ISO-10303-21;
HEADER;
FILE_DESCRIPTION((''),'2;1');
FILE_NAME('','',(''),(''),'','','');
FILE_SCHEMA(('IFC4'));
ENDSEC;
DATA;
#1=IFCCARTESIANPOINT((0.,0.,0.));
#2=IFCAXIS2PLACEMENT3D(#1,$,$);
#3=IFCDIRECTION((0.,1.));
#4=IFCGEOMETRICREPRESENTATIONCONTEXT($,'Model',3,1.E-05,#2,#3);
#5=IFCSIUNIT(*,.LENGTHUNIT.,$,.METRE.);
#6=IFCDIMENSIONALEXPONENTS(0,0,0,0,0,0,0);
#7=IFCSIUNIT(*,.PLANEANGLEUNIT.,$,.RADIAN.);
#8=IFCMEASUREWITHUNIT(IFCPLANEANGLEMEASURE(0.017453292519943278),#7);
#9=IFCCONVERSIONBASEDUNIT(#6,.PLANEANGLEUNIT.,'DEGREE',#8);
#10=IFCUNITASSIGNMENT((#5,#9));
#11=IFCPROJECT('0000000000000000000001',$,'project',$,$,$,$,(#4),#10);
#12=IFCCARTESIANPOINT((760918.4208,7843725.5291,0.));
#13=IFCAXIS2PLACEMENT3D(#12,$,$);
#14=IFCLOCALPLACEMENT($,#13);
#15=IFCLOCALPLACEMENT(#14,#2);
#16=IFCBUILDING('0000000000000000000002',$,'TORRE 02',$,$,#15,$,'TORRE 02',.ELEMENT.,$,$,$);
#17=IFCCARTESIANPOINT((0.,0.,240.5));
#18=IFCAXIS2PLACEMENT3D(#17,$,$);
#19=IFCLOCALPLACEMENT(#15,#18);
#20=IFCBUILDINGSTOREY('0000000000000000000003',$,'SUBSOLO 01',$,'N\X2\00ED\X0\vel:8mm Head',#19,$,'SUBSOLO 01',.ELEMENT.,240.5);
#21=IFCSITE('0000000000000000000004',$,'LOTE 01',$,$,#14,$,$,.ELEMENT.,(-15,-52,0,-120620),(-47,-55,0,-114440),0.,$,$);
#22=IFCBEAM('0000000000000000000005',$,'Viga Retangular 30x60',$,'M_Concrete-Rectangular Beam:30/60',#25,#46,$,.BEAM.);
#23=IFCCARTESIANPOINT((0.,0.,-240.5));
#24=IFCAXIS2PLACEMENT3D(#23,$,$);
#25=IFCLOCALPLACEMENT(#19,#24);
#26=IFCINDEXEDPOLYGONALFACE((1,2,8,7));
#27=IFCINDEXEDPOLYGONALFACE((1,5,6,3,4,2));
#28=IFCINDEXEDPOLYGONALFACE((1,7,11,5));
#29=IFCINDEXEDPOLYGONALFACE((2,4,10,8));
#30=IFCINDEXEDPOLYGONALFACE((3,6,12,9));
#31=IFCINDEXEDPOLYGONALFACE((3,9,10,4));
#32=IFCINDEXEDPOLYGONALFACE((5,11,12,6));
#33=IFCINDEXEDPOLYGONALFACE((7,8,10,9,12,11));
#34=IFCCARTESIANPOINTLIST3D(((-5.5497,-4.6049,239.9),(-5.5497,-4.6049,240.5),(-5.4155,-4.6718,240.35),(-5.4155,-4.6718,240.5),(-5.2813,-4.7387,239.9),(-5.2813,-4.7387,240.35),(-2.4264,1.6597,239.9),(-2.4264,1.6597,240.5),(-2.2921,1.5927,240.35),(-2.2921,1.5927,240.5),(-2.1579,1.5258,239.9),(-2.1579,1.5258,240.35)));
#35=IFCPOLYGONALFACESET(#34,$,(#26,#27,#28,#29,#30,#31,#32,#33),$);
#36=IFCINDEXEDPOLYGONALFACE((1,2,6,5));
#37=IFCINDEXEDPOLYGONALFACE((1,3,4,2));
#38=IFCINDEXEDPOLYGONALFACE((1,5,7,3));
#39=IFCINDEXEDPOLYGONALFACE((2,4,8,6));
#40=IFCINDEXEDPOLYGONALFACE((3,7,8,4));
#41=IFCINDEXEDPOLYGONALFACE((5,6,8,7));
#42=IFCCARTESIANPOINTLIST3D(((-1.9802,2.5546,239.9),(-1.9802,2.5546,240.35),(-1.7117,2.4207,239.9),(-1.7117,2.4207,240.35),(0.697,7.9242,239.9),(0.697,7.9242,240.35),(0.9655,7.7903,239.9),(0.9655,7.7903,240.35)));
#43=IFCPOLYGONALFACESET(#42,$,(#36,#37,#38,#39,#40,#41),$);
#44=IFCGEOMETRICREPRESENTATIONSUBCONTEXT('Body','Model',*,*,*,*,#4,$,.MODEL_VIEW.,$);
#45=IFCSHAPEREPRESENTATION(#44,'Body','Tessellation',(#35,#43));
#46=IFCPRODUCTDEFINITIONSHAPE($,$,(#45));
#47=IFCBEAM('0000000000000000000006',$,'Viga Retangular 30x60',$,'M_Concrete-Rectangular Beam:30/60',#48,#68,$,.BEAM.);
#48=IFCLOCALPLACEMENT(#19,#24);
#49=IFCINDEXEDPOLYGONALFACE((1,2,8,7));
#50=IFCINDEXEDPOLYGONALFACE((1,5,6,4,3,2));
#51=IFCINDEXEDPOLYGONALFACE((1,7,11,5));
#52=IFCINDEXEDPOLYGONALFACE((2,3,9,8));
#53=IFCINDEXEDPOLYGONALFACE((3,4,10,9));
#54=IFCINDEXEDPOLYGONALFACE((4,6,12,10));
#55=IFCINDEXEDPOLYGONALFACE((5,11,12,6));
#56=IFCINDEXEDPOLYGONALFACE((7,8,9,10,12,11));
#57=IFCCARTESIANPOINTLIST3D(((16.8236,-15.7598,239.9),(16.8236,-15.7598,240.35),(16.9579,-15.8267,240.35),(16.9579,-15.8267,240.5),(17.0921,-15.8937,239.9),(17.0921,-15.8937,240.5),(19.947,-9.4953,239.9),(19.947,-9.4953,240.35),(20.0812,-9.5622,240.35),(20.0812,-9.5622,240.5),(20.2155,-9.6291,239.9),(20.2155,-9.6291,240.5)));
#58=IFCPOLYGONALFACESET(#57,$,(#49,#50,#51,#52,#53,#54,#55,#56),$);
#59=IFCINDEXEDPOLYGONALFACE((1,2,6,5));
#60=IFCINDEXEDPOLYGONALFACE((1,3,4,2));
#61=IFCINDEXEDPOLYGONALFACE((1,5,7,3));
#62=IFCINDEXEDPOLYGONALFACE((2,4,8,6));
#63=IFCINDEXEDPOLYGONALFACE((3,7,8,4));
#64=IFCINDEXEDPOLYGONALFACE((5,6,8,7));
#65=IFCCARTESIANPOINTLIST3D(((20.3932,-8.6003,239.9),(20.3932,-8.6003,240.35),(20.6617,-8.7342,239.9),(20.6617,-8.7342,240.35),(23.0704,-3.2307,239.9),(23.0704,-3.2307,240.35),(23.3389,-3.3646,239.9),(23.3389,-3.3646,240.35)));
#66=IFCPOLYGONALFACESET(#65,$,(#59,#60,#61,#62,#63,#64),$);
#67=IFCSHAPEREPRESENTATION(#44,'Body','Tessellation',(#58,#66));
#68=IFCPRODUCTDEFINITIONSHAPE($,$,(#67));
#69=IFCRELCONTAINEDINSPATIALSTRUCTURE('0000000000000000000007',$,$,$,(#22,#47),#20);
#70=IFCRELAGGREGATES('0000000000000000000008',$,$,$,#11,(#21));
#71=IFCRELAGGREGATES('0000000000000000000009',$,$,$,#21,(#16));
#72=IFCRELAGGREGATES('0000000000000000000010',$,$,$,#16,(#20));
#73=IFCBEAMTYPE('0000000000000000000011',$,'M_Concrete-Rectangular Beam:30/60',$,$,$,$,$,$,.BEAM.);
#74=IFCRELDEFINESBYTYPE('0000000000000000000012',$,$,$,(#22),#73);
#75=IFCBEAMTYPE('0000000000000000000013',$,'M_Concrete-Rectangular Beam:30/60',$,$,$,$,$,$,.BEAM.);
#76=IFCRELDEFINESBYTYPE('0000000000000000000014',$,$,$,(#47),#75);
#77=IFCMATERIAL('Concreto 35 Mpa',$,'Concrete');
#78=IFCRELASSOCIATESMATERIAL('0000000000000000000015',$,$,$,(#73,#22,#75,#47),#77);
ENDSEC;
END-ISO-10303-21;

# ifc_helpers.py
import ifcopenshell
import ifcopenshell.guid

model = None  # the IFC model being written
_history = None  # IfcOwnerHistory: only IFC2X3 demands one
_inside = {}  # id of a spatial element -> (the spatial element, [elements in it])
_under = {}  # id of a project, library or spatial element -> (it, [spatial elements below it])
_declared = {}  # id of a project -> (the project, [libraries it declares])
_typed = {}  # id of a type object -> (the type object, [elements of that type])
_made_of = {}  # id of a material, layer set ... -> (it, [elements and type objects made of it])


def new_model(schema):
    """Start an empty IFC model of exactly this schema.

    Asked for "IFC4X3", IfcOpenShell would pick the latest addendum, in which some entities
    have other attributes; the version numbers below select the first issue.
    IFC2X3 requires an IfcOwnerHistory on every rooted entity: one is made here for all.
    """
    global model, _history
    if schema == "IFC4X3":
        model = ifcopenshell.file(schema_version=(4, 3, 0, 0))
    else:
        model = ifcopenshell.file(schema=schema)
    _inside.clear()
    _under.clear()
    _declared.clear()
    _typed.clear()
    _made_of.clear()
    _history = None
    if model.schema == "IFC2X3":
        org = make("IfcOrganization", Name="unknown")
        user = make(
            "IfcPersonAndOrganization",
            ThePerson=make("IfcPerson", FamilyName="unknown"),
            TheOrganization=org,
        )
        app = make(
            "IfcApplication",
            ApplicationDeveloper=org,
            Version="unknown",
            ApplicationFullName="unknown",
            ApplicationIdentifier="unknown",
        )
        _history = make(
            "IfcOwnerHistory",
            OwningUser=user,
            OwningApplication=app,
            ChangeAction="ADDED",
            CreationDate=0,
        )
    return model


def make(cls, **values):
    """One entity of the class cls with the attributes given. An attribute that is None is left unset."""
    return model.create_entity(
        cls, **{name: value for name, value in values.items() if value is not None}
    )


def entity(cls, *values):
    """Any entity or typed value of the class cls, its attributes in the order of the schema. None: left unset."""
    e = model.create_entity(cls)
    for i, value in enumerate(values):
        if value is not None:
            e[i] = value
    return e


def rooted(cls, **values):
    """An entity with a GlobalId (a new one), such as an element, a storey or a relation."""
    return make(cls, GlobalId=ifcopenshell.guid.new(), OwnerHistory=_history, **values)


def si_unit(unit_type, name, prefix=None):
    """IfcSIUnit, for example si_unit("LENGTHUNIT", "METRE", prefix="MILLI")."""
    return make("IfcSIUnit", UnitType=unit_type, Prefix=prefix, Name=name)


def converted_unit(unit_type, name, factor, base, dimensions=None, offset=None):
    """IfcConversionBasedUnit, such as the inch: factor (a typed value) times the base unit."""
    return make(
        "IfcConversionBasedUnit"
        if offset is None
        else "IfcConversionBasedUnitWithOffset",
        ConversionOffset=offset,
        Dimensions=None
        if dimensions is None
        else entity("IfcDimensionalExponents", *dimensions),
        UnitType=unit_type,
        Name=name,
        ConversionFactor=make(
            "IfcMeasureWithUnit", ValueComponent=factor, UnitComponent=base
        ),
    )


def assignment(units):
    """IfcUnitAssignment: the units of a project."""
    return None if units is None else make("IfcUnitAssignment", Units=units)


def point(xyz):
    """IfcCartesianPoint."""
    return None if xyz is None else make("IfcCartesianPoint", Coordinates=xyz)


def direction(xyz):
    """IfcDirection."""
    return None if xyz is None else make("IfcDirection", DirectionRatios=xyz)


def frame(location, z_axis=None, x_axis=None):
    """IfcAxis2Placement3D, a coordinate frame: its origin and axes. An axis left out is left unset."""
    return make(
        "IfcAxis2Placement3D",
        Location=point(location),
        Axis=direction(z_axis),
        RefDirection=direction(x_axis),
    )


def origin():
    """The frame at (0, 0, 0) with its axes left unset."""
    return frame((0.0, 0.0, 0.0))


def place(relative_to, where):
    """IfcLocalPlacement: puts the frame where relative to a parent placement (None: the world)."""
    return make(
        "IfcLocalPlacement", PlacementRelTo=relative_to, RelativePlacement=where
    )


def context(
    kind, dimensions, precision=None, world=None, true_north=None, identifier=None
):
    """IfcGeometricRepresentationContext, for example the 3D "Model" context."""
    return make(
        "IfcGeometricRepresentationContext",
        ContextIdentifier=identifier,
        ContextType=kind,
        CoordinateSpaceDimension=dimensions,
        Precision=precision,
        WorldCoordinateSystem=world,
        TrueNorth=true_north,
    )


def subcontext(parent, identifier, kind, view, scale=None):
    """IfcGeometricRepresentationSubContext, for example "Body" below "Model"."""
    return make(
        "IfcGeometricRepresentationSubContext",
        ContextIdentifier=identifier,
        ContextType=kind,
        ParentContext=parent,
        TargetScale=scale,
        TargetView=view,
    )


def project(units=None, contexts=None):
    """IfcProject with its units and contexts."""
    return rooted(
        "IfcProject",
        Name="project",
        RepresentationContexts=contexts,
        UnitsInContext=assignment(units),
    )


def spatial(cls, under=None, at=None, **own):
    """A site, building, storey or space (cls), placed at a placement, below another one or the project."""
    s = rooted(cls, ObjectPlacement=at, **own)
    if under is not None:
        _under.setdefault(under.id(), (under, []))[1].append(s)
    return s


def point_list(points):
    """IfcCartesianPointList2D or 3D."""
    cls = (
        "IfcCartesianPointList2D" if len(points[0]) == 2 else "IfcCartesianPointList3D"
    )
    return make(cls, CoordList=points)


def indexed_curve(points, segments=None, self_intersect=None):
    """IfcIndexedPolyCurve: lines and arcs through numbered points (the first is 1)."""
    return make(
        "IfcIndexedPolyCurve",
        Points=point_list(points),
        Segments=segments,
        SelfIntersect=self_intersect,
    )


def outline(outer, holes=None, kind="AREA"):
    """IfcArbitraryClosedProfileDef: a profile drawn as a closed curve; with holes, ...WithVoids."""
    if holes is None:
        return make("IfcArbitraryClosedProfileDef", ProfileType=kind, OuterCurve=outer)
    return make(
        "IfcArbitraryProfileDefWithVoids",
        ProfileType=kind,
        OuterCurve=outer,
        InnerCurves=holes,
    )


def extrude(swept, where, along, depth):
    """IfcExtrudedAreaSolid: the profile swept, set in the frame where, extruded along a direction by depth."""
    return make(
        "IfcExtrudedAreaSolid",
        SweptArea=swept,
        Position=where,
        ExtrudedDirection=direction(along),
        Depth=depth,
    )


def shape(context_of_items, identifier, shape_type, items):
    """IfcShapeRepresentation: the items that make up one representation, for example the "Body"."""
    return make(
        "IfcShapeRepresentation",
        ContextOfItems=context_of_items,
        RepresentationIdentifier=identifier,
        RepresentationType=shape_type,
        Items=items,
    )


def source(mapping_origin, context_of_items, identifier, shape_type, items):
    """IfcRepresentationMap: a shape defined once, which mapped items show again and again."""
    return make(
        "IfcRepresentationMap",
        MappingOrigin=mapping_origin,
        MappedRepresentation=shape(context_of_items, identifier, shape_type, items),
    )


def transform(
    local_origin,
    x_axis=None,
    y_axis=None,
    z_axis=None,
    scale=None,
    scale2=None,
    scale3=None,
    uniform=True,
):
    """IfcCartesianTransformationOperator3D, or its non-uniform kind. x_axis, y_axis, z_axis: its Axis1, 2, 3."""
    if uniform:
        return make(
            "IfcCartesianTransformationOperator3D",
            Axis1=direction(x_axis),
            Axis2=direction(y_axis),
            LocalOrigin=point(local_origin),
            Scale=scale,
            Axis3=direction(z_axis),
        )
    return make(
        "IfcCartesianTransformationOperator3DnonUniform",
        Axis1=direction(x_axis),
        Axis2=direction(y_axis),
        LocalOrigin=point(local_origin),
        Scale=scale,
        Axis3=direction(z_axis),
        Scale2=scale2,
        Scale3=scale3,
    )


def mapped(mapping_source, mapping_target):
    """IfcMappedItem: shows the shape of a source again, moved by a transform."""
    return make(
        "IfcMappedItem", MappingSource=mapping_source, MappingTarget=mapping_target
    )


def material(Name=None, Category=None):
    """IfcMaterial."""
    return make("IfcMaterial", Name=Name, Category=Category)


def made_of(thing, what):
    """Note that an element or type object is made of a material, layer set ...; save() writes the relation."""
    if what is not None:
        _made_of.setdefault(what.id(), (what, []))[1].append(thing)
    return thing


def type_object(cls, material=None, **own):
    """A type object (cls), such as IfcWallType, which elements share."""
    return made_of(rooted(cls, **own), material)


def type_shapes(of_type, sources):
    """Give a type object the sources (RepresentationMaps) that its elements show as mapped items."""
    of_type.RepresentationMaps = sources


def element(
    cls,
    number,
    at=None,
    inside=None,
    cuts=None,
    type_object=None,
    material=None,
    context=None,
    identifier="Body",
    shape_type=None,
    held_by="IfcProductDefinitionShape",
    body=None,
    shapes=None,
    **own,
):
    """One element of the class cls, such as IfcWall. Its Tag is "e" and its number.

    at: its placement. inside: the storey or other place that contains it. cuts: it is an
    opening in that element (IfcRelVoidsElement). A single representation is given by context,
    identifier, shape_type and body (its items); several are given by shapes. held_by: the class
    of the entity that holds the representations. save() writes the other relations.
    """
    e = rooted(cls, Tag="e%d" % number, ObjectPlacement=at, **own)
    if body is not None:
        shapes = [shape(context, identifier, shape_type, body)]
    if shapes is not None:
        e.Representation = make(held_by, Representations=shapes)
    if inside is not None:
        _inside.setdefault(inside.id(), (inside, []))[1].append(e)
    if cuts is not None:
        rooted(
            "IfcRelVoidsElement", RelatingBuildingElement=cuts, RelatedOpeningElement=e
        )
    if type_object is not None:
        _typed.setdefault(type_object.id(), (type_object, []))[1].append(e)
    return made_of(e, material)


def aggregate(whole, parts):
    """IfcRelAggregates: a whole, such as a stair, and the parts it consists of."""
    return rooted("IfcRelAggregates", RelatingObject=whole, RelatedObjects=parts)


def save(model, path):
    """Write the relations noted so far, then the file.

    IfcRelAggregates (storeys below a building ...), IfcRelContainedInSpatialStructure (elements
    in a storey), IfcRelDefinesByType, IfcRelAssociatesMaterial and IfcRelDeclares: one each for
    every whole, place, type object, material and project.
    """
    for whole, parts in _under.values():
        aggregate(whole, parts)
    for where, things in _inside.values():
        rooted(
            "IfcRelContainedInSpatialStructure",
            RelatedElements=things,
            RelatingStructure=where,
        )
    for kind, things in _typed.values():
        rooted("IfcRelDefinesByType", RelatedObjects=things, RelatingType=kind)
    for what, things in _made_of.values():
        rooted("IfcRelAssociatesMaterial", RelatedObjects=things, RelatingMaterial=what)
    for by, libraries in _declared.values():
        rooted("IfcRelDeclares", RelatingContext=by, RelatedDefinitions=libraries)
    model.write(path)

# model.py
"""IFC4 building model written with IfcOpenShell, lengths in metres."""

from ifc_helpers import new_model, entity, si_unit, converted_unit, direction, frame, origin, place, context, subcontext, project, spatial, indexed_curve, outline, extrude, source, transform, mapped, material, type_object, type_shapes, element, save


model = new_model("IFC4")

# Units and contexts
model_context = context("Model", 3, precision=1e-05, world=origin(), true_north=direction((0.0, 1.0)))
body_context = subcontext(model_context, "Body", "Model", "MODEL_VIEW")
ifc_project = project(units=[si_unit("LENGTHUNIT", "METRE"), converted_unit("PLANEANGLEUNIT", "DEGREE", entity("IfcPlaneAngleMeasure", 0.017453292519943278), si_unit("PLANEANGLEUNIT", "RADIAN"), dimensions=[0, 0, 0, 0, 0, 0, 0])], contexts=[model_context])

# Site, building, storey
site_placement = place(None, frame((760918.4208, 7843725.5291, 0.0)))
site = spatial("IfcSite", under=ifc_project, at=site_placement, Name="LOTE 01", CompositionType="ELEMENT", RefLatitude=(-15, -52, 0, -120620), RefLongitude=(-47, -55, 0, -114440), RefElevation=0.0)
building_placement = place(site_placement, origin())
building = spatial("IfcBuilding", under=site, at=building_placement, Name="TORRE 02", LongName="TORRE 02", CompositionType="ELEMENT")
storey_placement = place(building_placement, frame((0.0, 0.0, 240.5)))
storey = spatial("IfcBuildingStorey", under=building, at=storey_placement, Name="SUBSOLO 01", ObjectType="Nível:8mm Head", LongName="SUBSOLO 01", CompositionType="ELEMENT", Elevation=240.5)

# Shared definitions
ifc_material = material(Name="Concreto 35 Mpa", Category="Concrete")

# Beams
beam_type_1 = type_object("IfcBeamType", Name="M_Concrete-Rectangular Beam:30/60", PredefinedType="BEAM", material=ifc_material)
shared_shape_1 = source(origin(), body_context, "Body", "SweptSolid", [
    extrude(outline(indexed_curve([(-0.35, -0.15), (0.25, -0.15), (0.25, 0.0), (0.1, 0.0), (0.1, 0.15), (-0.35, 0.15), (-0.35, -0.15)], self_intersect=False)), frame((-5.4155, -4.6718, 240.25), z_axis=(0.446198, 0.894934, 0.0), x_axis=(0.0, 0.0, 1.0)), (0.0, 0.0, 1.0), 7.0),
    extrude(outline(indexed_curve([(-0.225, -0.15), (0.225, -0.15), (0.225, 0.15), (-0.225, 0.15), (-0.225, -0.15)], self_intersect=False)), frame((-1.8459, 2.4877, 240.125), z_axis=(0.446198, 0.894934, 0.0), x_axis=(0.0, 0.0, 1.0)), (0.0, 0.0, 1.0), 6.0),
])
type_shapes(beam_type_1, [shared_shape_1])
beam_1_placement = place(storey_placement, frame((0.0, 0.0, -240.5)))
element("IfcBeam", 1, at=beam_1_placement, inside=storey, type_object=beam_type_1, material=ifc_material, Name="Viga Retangular 30x60", ObjectType="M_Concrete-Rectangular Beam:30/60", PredefinedType="BEAM", context=body_context, shape_type="MappedRepresentation", body=[
    mapped(shared_shape_1, transform((0.0, 0.0, 0.0), scale=1.0)),
])
beam_type_2 = type_object("IfcBeamType", Name="M_Concrete-Rectangular Beam:30/60", PredefinedType="BEAM", material=ifc_material)
shared_shape_2 = source(origin(), body_context, "Body", "SweptSolid", [
    extrude(outline(indexed_curve([(-0.35, -0.15), (0.1, -0.15), (0.1, 0.0), (0.25, 0.0), (0.25, 0.15), (-0.35, 0.15), (-0.35, -0.15)], self_intersect=False)), frame((16.9579, -15.8267, 240.25), z_axis=(0.446198, 0.894934, 0.0), x_axis=(0.0, 0.0, 1.0)), (0.0, 0.0, 1.0), 7.0),
    extrude(outline(indexed_curve([(-0.225, -0.15), (0.225, -0.15), (0.225, 0.15), (-0.225, 0.15), (-0.225, -0.15)], self_intersect=False)), frame((20.5274, -8.6673, 240.125), z_axis=(0.446198, 0.894934, 0.0), x_axis=(0.0, 0.0, 1.0)), (0.0, 0.0, 1.0), 6.0),
])
type_shapes(beam_type_2, [shared_shape_2])
beam_2_placement = place(storey_placement, frame((0.0, 0.0, -240.5)))
element("IfcBeam", 2, at=beam_2_placement, inside=storey, type_object=beam_type_2, material=ifc_material, Name="Viga Retangular 30x60", ObjectType="M_Concrete-Rectangular Beam:30/60", PredefinedType="BEAM", context=body_context, shape_type="MappedRepresentation", body=[
    mapped(shared_shape_2, transform((0.0, 0.0, 0.0), scale=1.0)),
])

save(model, "model.ifc")
